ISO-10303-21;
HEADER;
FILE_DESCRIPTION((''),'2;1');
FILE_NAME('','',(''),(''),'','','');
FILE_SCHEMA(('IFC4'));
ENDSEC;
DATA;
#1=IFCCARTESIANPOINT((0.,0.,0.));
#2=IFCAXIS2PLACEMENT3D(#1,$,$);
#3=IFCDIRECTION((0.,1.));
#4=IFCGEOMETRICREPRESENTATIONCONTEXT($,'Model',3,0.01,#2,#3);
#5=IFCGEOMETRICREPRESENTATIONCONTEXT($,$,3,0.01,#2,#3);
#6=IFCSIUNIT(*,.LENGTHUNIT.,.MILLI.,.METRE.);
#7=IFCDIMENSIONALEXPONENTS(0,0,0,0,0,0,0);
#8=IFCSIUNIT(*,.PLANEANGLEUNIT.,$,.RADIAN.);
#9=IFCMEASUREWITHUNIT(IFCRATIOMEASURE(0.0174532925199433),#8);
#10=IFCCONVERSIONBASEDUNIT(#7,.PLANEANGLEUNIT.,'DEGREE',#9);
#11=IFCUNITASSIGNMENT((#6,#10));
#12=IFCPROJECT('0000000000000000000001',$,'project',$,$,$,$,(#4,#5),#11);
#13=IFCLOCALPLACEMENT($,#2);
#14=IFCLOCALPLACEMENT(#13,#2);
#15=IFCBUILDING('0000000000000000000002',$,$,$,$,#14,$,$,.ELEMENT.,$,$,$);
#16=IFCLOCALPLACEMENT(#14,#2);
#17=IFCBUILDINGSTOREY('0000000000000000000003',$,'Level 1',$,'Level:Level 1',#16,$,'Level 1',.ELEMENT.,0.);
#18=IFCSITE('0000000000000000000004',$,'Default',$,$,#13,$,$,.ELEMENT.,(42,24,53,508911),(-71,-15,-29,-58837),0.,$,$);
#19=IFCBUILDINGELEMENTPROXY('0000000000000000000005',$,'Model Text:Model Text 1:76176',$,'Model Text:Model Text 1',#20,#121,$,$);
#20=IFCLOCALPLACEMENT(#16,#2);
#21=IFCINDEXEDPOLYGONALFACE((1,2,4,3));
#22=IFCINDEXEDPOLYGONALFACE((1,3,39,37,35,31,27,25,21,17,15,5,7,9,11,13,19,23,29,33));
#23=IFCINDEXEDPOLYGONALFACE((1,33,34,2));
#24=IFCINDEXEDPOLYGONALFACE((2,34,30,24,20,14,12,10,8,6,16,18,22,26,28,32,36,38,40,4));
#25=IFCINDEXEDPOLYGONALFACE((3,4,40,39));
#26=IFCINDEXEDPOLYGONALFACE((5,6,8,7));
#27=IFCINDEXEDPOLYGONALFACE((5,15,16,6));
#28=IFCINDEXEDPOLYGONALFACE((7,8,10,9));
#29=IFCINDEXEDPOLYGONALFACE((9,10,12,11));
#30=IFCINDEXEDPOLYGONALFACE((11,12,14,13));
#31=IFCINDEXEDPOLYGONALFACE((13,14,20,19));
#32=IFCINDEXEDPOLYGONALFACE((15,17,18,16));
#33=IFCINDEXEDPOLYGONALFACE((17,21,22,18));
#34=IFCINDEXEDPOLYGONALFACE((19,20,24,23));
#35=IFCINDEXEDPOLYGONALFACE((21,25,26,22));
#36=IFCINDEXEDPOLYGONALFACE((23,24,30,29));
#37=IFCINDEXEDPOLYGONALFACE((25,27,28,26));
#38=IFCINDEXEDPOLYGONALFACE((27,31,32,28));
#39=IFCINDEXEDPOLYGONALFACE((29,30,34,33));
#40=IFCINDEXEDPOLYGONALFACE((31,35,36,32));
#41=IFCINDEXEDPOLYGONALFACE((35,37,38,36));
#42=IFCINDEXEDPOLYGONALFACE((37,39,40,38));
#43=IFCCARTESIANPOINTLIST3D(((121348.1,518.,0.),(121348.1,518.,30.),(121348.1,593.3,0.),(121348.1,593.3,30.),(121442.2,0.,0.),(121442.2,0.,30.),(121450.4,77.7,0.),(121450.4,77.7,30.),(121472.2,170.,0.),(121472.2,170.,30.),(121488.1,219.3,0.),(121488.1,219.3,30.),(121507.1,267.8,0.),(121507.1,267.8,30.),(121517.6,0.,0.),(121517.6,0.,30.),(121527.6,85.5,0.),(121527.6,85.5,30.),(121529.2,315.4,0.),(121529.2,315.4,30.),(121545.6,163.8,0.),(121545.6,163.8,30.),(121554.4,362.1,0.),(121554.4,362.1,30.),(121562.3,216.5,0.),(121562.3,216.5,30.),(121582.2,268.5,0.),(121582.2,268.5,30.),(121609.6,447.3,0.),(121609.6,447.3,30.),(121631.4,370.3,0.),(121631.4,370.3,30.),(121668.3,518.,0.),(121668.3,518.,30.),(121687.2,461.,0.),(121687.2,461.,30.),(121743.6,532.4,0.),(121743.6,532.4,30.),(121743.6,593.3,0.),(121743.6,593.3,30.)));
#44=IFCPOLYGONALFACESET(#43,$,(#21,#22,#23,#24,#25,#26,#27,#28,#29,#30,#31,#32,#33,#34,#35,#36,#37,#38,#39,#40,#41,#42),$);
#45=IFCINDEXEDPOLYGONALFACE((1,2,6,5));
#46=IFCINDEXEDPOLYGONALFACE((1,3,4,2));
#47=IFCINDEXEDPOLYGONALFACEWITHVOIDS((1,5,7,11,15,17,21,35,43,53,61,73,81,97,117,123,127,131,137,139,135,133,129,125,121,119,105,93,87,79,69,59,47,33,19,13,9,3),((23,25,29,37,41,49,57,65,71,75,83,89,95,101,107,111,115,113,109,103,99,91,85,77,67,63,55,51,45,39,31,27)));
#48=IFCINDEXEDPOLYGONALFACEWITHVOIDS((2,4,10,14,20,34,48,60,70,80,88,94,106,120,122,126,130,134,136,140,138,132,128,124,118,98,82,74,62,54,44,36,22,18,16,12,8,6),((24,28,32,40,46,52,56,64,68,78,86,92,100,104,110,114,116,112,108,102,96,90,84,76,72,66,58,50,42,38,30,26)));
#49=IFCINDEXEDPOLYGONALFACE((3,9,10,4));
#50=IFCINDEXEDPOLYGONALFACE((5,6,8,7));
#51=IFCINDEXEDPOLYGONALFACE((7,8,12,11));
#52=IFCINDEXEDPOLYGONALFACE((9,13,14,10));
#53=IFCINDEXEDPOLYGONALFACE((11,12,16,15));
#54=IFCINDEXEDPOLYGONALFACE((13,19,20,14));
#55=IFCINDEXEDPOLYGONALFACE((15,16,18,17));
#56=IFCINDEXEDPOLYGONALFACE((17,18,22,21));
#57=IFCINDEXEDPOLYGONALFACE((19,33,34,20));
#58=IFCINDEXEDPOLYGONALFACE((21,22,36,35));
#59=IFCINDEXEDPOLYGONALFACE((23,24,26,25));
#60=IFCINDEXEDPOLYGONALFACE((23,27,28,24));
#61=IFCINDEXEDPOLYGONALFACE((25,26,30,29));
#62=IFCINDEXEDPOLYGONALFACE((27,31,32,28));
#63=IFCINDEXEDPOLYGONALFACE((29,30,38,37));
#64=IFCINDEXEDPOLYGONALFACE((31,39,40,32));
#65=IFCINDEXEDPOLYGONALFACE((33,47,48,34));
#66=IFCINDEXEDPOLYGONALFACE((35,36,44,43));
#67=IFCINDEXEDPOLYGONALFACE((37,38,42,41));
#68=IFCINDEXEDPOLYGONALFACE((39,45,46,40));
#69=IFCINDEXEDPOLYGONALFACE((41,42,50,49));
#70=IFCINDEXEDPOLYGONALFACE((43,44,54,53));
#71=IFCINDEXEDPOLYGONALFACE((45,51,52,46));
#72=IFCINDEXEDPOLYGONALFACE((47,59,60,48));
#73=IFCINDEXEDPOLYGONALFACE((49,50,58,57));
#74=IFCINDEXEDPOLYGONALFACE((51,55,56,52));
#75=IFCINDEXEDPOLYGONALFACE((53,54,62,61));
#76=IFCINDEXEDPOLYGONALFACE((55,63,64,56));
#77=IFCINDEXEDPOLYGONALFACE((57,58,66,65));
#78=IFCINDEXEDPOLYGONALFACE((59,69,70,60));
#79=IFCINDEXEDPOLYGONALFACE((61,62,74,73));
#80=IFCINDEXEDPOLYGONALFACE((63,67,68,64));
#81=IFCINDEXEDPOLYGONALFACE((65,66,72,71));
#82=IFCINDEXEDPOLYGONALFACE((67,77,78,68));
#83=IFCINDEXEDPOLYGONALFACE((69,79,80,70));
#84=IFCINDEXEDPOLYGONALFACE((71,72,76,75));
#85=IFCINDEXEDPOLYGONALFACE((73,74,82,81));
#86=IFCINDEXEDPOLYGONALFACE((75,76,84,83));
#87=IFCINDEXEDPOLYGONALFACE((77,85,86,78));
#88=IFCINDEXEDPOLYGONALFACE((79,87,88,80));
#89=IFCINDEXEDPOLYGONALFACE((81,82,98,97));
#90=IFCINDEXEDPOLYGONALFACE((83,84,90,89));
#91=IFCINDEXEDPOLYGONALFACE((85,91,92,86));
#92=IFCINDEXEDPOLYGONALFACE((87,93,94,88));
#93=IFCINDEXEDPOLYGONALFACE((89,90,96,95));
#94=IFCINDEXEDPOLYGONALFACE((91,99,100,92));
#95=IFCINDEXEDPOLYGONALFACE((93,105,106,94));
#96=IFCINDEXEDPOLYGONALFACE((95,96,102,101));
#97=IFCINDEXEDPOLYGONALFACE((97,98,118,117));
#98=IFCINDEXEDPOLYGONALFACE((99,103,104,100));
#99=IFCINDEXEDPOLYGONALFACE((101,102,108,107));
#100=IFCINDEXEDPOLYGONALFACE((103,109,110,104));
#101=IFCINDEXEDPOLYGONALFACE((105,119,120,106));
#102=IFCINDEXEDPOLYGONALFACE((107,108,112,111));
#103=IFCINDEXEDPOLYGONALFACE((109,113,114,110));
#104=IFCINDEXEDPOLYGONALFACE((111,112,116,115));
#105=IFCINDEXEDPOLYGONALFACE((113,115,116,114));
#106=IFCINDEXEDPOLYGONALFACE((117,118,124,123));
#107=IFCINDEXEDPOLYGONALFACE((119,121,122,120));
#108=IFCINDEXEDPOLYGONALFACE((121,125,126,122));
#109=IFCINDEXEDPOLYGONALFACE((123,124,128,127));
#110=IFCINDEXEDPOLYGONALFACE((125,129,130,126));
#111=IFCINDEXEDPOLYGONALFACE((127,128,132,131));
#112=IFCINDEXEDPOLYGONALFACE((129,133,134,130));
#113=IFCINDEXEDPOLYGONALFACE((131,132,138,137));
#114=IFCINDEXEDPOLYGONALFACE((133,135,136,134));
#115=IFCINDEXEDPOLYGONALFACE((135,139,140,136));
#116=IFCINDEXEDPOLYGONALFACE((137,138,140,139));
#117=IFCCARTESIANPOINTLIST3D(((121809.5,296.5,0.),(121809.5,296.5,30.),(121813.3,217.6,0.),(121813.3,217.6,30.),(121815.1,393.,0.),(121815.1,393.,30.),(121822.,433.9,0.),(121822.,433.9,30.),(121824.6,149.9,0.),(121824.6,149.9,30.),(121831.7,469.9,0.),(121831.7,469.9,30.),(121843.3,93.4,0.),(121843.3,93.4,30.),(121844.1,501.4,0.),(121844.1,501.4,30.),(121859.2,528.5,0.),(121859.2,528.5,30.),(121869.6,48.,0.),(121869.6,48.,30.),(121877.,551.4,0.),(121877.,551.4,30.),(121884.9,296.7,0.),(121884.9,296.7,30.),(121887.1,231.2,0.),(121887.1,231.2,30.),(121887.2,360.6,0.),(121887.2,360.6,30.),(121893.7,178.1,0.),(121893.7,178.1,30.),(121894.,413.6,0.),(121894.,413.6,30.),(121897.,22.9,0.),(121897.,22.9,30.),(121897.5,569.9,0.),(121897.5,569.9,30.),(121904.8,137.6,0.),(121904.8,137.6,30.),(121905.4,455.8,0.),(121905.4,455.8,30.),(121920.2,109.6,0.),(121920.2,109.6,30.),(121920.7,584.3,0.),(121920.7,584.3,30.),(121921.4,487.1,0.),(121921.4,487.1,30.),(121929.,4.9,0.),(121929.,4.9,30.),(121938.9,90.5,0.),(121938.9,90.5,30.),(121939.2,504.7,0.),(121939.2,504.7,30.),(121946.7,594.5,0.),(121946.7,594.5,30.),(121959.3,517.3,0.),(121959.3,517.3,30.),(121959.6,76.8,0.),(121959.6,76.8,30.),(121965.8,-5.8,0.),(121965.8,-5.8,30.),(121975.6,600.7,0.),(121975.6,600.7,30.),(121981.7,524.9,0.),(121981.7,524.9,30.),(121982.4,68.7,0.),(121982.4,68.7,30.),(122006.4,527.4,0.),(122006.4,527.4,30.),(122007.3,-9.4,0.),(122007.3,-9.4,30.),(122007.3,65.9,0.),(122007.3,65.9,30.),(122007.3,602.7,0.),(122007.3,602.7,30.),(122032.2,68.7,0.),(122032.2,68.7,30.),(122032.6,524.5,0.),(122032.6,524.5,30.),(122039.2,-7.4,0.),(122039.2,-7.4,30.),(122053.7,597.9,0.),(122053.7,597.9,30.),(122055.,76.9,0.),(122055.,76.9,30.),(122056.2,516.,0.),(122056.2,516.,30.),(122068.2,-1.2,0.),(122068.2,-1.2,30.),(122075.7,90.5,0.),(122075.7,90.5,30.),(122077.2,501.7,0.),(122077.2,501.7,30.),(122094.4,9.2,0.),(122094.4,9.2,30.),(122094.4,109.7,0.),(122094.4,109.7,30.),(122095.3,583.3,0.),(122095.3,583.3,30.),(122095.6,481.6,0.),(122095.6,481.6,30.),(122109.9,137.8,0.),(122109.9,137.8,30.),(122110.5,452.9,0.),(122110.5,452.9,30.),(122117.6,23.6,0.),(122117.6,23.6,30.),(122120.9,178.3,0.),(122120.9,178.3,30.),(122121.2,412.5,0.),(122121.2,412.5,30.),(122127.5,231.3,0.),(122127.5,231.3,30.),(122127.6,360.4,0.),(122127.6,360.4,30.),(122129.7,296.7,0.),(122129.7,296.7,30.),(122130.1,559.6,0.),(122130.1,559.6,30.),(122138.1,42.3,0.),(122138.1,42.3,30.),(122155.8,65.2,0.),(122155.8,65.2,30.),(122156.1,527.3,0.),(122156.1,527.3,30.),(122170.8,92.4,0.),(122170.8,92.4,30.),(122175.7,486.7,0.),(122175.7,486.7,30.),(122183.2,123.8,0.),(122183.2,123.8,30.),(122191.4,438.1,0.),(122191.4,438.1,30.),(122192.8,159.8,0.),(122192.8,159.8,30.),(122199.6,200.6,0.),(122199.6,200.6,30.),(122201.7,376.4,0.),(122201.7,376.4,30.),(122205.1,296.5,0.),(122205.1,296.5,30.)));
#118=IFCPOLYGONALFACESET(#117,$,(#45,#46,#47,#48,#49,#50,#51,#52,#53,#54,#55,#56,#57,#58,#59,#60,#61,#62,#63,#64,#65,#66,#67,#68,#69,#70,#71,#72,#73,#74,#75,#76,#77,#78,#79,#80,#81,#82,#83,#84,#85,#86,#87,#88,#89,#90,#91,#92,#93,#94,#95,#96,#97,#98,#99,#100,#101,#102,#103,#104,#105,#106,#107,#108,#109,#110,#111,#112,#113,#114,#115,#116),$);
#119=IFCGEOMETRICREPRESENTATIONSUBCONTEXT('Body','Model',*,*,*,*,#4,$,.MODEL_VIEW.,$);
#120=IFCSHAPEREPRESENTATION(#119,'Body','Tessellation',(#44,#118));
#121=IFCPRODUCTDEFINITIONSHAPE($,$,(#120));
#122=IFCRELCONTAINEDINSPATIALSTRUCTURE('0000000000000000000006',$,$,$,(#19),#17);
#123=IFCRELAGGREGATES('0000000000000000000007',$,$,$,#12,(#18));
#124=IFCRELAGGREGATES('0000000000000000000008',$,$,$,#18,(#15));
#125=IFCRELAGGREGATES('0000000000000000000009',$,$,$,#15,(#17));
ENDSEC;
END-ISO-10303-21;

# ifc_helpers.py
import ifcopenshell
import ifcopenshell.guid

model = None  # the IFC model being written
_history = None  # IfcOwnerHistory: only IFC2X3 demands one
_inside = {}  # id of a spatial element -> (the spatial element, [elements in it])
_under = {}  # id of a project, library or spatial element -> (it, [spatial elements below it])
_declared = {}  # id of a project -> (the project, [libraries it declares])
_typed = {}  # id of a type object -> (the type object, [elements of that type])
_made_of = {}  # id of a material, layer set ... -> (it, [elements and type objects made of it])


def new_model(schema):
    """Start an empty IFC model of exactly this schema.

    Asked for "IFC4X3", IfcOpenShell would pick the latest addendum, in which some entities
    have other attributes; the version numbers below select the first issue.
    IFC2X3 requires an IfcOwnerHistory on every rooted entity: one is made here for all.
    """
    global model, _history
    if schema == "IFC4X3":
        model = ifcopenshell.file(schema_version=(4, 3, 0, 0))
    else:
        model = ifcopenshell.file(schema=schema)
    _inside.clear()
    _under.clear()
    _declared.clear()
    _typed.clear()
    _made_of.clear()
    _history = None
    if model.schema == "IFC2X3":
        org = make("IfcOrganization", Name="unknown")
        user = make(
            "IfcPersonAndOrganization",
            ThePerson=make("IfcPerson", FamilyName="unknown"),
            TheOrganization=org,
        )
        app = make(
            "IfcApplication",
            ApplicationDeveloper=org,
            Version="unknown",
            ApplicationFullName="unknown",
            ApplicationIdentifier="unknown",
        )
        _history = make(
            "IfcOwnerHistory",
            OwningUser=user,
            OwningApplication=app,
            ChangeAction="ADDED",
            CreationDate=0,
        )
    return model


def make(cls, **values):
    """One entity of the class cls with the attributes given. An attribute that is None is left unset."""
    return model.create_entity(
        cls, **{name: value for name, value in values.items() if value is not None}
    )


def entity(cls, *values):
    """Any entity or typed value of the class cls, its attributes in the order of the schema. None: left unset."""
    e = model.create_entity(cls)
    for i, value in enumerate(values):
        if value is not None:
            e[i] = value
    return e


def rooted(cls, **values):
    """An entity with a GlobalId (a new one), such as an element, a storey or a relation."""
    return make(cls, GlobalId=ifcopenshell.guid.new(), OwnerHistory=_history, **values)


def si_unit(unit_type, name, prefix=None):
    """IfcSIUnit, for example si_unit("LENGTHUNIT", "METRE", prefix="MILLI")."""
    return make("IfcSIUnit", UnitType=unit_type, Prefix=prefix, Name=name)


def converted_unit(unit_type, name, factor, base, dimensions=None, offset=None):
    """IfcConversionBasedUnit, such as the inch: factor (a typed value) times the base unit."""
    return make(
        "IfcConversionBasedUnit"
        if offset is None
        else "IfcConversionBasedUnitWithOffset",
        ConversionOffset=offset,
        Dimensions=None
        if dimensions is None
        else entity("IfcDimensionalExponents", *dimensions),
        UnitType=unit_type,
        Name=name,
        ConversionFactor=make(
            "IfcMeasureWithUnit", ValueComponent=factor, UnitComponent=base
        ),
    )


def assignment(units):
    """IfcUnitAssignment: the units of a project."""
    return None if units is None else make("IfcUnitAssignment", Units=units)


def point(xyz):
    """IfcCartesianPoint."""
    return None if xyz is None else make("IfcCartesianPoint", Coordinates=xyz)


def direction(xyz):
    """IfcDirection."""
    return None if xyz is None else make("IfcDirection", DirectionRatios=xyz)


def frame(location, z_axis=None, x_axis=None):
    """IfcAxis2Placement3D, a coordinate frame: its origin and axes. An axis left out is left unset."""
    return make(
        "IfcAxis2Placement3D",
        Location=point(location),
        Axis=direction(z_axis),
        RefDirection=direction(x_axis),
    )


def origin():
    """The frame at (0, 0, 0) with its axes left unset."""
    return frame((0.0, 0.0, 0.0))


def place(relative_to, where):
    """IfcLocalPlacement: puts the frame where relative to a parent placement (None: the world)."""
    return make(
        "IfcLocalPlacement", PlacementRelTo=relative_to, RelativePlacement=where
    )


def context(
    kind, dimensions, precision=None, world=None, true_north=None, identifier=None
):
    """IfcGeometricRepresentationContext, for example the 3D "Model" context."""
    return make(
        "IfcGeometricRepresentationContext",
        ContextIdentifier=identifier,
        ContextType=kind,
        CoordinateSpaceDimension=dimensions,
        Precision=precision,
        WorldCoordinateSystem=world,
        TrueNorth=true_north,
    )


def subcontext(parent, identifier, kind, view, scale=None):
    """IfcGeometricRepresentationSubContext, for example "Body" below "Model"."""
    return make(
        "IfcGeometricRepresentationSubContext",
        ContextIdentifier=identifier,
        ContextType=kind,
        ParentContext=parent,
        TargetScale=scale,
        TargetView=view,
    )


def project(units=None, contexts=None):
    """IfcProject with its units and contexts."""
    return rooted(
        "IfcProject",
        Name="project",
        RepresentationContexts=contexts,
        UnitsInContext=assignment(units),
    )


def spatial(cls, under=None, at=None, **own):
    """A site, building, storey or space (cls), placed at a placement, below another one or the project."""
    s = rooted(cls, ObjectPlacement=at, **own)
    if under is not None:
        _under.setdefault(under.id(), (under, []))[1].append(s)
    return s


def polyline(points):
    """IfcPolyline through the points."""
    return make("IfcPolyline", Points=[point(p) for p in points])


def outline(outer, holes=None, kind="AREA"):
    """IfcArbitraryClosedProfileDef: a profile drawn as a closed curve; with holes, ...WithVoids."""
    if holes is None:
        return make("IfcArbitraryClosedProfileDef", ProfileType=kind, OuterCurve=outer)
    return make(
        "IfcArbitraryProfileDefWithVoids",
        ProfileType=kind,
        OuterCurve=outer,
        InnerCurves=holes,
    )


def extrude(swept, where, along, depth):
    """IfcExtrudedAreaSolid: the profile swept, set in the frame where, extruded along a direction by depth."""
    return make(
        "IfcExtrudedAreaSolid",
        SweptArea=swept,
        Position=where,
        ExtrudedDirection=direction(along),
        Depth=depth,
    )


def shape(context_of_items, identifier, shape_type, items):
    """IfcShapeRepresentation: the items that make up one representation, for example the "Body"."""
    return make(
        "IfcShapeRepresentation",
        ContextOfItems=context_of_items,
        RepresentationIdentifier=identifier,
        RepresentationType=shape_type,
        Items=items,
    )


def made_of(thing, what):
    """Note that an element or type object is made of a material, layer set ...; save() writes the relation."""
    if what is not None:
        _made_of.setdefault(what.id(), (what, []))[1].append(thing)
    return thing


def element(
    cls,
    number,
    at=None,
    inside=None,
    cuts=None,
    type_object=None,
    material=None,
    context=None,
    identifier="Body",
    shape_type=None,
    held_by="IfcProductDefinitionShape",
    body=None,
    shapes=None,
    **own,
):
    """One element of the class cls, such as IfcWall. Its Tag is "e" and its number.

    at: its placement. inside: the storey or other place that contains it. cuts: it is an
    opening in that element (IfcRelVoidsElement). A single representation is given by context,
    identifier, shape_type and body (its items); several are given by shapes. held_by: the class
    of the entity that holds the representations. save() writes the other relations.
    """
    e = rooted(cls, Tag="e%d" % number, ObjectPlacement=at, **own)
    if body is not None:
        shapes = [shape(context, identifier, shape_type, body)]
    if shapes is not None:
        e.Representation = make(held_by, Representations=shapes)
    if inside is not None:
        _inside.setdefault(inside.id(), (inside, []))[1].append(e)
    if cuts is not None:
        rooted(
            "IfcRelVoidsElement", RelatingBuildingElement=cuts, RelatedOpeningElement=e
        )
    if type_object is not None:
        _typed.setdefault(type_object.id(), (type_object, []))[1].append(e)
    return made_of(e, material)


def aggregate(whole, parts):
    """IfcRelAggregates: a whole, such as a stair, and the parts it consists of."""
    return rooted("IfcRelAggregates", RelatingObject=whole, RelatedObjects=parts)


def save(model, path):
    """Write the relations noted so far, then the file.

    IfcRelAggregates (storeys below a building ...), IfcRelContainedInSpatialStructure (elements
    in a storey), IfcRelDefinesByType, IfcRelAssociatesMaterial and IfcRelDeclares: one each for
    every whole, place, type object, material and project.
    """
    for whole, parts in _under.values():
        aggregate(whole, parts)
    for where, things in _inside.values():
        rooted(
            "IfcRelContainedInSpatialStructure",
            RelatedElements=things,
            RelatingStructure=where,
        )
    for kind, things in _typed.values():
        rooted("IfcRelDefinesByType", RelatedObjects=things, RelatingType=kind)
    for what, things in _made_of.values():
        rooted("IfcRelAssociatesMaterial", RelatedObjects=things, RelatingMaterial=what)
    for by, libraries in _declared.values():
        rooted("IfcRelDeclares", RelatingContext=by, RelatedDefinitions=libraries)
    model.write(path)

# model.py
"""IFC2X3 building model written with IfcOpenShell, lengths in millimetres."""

from ifc_helpers import new_model, entity, si_unit, converted_unit, direction, frame, origin, place, context, subcontext, project, spatial, polyline, outline, extrude, element, save


model = new_model("IFC2X3")

# Units and contexts
model_context = context("Model", 3, precision=0.01, world=origin(), true_north=direction((0.0, 1.0)))
context_of_model = context(None, 3, precision=0.01, world=origin(), true_north=direction((0.0, 1.0)))
body_context = subcontext(model_context, "Body", "Model", "MODEL_VIEW")
ifc_project = project(units=[si_unit("LENGTHUNIT", "METRE", prefix="MILLI"), converted_unit("PLANEANGLEUNIT", "DEGREE", entity("IfcRatioMeasure", 0.0174532925199433), si_unit("PLANEANGLEUNIT", "RADIAN"), dimensions=[0, 0, 0, 0, 0, 0, 0])], contexts=[model_context, context_of_model])

# Site, building, storey
site_placement = place(None, origin())
site = spatial("IfcSite", under=ifc_project, at=site_placement, Name="Default", CompositionType="ELEMENT", RefLatitude=(42, 24, 53, 508911), RefLongitude=(-71, -15, -29, -58837), RefElevation=0.0)
building_placement = place(site_placement, origin())
building = spatial("IfcBuilding", under=site, at=building_placement, CompositionType="ELEMENT")
storey_placement = place(building_placement, origin())
storey = spatial("IfcBuildingStorey", under=building, at=storey_placement, Name="Level 1", ObjectType="Level:Level 1", LongName="Level 1", CompositionType="ELEMENT", Elevation=0.0)

# Building element proxy
proxy_1_placement = place(storey_placement, origin())
element("IfcBuildingElementProxy", 1, at=proxy_1_placement, inside=storey, Name="Model Text:Model Text 1:76176", ObjectType="Model Text:Model Text 1", context=body_context, shape_type="SweptSolid", body=[
    extrude(outline(polyline([(-199.9, -209.0), (-199.9, -284.3), (195.7, -284.3), (195.7, -223.4), (139.3, -152.0), (83.5, -61.3), (34.2, 40.5), (14.4, 92.5), (-2.4, 145.2), (-20.3, 223.5), (-30.3, 309.0), (-105.7, 309.0), (-97.5, 231.3), (-75.7, 139.0), (-59.9, 89.7), (-40.9, 41.2), (-18.8, -6.4), (6.4, -53.1), (61.7, -138.3), (120.3, -209.0), (-199.9, -209.0)])), frame((121547.9, 309.0, 0.0), z_axis=(0.0, 0.0, -1.0), x_axis=(1.0, 0.0, 0.0)), (0.0, 0.0, -1.0), 30.0),
    extrude(outline(polyline([(-10.6, -198.7), (68.3, -198.7), (136.5, -190.7), (193.9, -174.7), (240.5, -150.6), (266.9, -124.4), (286.3, -93.2), (298.8, -57.0), (304.3, -15.7), (303.8, 16.2), (299.0, 45.5), (289.9, 72.1), (276.6, 96.0), (258.9, 117.3), (236.9, 136.2), (210.4, 152.5), (179.6, 166.3), (144.1, 177.6), (103.7, 186.3), (8.2, 196.4), (-71.8, 196.7), (-134.0, 189.4), (-183.3, 176.1), (-224.7, 158.4), (-258.2, 133.9), (-283.5, 100.3), (-300.1, 59.5), (-307.1, 13.4), (-306.6, -18.4), (-301.8, -47.5), (-292.8, -74.0), (-279.6, -97.9), (-262.0, -119.2), (-240.0, -138.1), (-213.6, -154.5), (-182.8, -168.4), (-147.3, -179.8), (-106.7, -188.6), (-10.6, -198.7)]), holes=[polyline([(-7.2, -123.5), (-71.0, -118.2), (-123.6, -108.8), (-165.2, -95.4), (-195.7, -78.0), (-212.4, -59.4), (-224.1, -38.7), (-230.6, -15.9), (-231.9, 8.9), (-227.8, 35.0), (-218.1, 58.1), (-202.8, 78.4), (-182.0, 95.8), (-152.6, 109.4), (-111.7, 118.1), (-59.4, 122.0), (4.4, 121.1), (69.6, 115.8), (122.2, 106.7), (162.2, 93.7), (189.5, 77.0), (207.7, 57.4), (220.4, 36.0), (227.5, 12.8), (229.1, -12.1), (225.2, -36.8), (215.9, -59.2), (201.3, -79.3), (181.4, -97.1), (152.6, -111.2), (111.6, -120.3), (58.3, -124.4), (-7.2, -123.5)])]), frame((122008.6, 295.3, 0.0), z_axis=(0.0, 0.0, 1.0), x_axis=(0.047515, -0.998871, 0.0)), (0.0, 0.0, 1.0), 30.0),
])

save(model, "model.ifc")
